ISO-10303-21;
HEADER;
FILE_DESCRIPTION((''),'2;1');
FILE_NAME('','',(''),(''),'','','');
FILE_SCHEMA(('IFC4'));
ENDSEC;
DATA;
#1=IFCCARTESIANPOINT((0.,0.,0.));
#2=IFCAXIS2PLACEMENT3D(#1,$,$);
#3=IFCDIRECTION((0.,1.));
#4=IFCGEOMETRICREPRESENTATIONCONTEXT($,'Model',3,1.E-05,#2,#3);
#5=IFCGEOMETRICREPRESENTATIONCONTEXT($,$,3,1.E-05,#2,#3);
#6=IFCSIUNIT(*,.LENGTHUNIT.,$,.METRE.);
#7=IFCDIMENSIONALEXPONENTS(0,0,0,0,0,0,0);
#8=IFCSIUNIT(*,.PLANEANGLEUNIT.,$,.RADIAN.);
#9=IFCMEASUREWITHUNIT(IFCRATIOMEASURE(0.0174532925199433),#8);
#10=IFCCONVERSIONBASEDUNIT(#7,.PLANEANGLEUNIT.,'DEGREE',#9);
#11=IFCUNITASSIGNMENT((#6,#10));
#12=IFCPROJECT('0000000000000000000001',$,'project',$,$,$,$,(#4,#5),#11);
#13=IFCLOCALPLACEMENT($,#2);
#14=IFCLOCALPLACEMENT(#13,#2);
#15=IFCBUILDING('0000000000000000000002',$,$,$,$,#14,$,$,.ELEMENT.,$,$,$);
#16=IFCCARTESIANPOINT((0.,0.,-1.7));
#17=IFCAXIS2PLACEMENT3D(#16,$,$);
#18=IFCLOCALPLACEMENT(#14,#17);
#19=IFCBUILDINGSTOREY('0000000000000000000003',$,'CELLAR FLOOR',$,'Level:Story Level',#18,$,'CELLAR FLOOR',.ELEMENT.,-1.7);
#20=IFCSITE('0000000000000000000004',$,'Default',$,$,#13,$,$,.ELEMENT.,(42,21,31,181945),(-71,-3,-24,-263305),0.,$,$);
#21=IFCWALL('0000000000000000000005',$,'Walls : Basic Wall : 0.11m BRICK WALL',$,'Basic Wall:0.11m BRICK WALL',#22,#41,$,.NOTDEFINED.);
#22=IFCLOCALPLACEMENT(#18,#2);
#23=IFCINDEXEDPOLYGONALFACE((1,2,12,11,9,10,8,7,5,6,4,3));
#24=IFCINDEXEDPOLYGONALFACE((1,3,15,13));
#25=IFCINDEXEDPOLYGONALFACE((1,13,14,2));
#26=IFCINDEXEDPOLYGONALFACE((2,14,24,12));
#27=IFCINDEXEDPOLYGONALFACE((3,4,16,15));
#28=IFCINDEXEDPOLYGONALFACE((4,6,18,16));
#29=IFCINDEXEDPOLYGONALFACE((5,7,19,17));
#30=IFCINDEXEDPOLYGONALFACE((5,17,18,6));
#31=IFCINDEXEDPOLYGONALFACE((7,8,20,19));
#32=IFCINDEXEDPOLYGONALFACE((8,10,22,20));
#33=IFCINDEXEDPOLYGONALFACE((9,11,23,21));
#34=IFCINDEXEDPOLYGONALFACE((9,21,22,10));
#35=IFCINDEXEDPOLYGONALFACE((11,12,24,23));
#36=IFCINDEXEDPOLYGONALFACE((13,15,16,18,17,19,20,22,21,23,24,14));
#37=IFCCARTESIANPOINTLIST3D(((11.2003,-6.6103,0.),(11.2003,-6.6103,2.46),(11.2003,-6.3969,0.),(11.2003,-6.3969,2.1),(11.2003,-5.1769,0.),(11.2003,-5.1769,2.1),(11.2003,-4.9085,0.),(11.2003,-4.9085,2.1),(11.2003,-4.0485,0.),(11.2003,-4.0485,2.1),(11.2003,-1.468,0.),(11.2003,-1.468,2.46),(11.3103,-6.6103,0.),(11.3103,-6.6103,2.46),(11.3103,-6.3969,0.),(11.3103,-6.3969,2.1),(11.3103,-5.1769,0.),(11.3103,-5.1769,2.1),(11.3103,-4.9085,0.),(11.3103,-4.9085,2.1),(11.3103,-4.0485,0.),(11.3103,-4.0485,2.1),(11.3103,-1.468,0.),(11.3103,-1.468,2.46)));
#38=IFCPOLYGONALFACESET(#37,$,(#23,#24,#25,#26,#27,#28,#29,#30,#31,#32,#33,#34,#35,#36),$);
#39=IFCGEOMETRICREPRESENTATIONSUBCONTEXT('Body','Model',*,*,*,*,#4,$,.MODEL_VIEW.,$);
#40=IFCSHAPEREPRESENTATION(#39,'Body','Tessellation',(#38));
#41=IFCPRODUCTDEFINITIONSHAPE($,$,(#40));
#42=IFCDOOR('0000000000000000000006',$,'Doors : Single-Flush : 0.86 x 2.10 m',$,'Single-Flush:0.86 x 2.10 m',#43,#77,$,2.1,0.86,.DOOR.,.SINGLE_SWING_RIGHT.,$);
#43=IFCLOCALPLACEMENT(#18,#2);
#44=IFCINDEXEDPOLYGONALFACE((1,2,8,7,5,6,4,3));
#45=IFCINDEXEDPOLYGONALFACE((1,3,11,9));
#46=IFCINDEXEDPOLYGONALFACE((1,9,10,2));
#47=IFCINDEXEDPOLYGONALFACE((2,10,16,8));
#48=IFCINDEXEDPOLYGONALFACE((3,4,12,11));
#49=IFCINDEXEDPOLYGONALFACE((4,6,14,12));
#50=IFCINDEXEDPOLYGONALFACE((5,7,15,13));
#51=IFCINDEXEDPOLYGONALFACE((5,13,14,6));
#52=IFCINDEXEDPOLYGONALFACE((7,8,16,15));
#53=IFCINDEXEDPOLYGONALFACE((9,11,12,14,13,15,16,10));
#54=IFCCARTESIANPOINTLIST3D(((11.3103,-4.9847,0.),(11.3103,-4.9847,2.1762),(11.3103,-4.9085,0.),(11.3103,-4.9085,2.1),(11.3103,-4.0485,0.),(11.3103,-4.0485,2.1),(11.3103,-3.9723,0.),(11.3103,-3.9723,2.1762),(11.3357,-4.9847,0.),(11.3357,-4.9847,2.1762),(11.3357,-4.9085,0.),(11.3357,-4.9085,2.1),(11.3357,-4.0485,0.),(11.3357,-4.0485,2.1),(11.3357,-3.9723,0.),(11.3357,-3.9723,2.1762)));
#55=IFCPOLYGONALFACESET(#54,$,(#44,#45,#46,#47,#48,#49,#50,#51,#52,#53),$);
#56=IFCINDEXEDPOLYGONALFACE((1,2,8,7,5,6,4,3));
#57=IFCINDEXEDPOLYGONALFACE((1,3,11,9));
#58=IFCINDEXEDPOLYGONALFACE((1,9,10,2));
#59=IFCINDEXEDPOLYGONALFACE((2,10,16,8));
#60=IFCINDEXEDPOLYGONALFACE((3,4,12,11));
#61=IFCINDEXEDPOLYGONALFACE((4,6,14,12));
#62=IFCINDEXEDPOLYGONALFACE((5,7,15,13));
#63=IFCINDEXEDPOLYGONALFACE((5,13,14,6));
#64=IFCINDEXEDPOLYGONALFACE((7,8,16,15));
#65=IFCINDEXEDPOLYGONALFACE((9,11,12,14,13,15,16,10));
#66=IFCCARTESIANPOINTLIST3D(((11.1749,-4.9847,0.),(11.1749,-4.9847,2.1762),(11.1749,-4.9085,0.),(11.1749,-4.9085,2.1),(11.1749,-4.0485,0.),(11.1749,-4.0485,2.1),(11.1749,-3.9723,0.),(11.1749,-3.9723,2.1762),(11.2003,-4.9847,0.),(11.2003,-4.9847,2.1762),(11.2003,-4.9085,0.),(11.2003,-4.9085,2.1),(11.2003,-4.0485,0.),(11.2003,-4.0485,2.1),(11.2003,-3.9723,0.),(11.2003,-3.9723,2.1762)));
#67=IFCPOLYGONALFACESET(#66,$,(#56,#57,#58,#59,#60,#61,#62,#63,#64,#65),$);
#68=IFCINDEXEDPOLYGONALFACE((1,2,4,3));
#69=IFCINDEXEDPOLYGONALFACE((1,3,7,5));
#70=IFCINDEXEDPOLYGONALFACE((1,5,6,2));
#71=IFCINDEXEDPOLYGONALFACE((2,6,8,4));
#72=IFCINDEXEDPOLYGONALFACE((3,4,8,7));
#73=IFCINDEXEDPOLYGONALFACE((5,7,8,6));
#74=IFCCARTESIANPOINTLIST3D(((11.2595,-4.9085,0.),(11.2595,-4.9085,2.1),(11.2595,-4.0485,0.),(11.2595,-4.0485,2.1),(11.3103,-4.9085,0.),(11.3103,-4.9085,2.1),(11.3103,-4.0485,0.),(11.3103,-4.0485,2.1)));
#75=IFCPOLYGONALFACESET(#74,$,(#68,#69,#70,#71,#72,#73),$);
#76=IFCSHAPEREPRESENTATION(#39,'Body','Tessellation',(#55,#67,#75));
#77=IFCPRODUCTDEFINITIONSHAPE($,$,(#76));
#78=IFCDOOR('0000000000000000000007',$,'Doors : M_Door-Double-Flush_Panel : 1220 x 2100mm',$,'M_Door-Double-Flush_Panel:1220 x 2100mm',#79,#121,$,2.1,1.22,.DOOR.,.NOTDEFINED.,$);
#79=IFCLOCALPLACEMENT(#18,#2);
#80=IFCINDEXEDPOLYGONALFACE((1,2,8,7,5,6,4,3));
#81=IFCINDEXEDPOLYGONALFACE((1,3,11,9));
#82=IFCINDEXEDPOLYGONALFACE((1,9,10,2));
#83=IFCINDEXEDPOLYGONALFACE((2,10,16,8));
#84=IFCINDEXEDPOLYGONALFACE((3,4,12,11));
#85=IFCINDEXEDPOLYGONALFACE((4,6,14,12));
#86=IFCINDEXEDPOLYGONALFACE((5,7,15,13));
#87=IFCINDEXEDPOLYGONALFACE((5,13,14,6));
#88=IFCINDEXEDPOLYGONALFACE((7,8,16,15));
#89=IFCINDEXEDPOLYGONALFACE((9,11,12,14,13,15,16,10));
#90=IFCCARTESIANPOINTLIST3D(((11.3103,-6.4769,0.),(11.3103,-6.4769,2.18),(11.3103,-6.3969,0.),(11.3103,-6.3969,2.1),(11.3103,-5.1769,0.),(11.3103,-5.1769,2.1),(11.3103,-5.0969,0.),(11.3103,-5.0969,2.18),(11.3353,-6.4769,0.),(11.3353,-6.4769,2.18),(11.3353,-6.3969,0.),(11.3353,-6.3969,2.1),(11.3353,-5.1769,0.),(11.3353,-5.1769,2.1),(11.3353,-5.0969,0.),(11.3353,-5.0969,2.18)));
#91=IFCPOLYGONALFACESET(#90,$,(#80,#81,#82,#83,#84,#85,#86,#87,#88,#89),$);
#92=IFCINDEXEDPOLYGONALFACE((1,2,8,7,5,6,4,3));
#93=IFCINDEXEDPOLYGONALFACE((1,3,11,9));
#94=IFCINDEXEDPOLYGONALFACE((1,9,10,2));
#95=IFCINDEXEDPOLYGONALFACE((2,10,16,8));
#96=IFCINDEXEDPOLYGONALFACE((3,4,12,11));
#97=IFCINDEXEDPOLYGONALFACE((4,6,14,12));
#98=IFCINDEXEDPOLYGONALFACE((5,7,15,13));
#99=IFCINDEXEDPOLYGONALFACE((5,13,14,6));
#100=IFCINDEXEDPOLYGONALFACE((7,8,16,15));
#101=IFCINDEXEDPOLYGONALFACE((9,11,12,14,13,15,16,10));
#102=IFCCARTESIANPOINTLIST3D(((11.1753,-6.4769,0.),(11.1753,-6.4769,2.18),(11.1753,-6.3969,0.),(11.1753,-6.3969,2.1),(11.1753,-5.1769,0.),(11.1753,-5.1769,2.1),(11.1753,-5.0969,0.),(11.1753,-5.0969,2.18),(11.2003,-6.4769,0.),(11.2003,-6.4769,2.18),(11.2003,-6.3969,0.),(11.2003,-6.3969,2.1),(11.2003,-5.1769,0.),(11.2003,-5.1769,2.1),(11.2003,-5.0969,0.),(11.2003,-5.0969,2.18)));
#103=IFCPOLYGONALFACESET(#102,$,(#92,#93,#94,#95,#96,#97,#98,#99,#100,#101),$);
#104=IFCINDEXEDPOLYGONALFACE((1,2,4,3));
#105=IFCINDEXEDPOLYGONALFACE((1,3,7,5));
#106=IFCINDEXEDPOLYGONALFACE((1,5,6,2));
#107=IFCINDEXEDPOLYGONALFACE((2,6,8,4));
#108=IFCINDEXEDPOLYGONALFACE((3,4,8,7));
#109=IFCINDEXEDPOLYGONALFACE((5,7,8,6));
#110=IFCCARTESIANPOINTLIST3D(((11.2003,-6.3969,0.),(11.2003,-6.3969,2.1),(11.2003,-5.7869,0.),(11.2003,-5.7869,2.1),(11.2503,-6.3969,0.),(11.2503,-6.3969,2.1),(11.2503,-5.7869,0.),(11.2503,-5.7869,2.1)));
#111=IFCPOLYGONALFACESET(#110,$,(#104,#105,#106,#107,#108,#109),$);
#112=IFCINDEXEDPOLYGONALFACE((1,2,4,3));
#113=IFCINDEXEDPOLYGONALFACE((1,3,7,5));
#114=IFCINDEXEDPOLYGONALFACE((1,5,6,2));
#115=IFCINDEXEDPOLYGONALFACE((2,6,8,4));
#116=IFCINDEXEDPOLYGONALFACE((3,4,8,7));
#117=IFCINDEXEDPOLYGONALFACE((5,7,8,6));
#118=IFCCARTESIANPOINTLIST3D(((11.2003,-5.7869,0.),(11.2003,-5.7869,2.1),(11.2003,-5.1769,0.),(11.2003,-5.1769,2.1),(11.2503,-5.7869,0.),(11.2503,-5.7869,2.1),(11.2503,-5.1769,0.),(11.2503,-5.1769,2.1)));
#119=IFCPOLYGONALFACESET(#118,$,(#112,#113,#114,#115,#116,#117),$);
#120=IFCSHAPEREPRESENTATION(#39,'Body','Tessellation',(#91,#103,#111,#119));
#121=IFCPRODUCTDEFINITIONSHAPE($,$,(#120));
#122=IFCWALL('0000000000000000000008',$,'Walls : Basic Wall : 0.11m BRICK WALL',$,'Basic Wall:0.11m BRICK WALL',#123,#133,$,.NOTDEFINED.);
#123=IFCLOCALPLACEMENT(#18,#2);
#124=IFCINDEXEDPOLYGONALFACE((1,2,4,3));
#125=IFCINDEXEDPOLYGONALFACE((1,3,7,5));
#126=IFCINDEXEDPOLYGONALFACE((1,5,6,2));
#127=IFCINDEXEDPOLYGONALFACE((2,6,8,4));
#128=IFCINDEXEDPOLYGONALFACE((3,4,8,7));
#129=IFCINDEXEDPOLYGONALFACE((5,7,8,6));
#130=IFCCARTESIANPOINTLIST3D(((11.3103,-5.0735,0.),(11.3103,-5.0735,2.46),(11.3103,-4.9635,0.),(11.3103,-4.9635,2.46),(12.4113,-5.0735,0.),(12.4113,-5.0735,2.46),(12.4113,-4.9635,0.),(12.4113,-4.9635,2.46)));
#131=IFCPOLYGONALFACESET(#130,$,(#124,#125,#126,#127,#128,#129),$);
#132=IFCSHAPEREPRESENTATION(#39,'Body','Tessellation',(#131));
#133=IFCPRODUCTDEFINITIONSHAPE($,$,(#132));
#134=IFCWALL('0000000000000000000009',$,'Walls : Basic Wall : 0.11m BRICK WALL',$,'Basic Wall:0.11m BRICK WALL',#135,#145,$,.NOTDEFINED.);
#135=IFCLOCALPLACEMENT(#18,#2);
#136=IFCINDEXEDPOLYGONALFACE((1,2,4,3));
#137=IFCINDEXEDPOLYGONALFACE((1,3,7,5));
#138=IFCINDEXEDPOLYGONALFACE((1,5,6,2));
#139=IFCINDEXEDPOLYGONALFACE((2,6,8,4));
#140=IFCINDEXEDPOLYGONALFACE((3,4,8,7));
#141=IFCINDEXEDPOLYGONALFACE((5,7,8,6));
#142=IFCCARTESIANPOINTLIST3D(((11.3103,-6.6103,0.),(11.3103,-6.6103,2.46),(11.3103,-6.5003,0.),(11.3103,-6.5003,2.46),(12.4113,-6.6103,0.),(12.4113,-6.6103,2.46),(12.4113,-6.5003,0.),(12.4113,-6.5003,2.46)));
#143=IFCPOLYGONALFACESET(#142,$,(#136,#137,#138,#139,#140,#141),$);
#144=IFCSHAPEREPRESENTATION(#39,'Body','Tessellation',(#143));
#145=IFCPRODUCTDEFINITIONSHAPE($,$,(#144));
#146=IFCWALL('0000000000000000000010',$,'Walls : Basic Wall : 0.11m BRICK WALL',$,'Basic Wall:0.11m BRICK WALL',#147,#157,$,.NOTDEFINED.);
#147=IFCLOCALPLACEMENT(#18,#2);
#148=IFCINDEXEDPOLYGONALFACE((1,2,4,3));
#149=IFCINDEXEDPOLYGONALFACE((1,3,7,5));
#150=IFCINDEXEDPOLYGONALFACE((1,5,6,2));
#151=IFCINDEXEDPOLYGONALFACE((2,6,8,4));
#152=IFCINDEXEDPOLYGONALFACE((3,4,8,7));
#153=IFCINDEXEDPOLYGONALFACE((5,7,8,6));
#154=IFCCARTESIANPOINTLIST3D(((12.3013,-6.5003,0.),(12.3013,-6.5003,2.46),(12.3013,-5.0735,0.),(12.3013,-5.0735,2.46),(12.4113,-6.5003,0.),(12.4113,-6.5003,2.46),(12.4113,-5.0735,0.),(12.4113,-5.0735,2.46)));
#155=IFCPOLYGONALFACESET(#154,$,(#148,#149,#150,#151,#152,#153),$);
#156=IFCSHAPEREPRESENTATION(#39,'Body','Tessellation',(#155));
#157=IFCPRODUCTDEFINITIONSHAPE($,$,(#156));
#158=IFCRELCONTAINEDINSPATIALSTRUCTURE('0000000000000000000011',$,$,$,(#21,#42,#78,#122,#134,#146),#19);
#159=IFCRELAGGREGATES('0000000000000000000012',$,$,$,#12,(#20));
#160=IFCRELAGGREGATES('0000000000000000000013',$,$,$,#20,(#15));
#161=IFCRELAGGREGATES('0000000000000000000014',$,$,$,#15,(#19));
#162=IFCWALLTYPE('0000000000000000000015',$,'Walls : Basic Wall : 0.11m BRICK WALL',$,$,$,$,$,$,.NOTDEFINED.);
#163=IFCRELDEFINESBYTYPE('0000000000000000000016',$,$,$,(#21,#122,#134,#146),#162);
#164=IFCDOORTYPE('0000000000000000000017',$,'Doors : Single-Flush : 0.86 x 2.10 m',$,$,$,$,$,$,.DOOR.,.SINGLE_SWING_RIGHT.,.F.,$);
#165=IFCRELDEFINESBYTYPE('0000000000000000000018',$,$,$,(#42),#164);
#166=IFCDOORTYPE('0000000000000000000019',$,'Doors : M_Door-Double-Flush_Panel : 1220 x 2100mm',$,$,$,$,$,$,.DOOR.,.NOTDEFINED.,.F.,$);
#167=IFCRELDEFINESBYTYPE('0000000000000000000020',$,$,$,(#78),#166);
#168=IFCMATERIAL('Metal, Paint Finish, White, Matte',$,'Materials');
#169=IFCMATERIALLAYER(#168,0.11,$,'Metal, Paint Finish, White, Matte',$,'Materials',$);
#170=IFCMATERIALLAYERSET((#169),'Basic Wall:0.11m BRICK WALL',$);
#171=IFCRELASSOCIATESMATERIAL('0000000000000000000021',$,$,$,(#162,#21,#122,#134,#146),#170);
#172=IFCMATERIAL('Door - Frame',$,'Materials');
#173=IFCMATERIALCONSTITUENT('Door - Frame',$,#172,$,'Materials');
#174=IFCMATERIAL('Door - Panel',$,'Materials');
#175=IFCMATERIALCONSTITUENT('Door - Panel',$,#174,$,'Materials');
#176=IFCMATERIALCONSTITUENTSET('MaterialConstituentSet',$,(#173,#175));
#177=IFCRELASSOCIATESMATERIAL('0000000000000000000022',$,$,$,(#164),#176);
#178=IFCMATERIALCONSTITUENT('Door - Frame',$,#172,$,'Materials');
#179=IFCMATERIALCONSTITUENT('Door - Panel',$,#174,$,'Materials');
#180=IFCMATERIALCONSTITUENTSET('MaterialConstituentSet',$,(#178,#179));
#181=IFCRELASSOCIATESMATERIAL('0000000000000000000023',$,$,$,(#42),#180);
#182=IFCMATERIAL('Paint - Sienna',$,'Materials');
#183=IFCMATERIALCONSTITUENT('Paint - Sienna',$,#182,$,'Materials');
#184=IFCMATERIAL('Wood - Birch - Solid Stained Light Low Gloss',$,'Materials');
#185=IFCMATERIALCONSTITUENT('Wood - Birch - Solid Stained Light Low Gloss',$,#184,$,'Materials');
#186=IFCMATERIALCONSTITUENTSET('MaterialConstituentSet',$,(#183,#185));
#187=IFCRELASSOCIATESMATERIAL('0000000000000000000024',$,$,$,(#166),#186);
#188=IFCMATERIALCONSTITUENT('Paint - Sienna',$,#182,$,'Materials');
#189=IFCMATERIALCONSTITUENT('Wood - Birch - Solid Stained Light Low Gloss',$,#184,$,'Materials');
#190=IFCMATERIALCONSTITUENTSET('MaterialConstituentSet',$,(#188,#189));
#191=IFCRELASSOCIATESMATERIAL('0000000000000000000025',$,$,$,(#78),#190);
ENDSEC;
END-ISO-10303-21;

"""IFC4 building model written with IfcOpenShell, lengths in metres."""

from ifc_helpers import new_model, entity, si_unit, converted_unit, direction, frame, frame_2d, origin, origin_2d_with_axis, place, context, subcontext, project, spatial, polyline, rectangle, outline, extrude, source, transform, mapped, material, layer, layer_set, layer_usage, constituent, constituent_set, type_object, type_shapes, element, fill, save


model = new_model("IFC4")

# Units and contexts
model_context = context("Model", 3, precision=1e-05, world=origin(), true_north=direction((0.0, 1.0)))
context_of_model = context(None, 3, precision=1e-05, world=origin(), true_north=direction((0.0, 1.0)))
body_context = subcontext(model_context, "Body", "Model", "MODEL_VIEW")
ifc_project = project(units=[si_unit("LENGTHUNIT", "METRE"), converted_unit("PLANEANGLEUNIT", "DEGREE", entity("IfcRatioMeasure", 0.0174532925199433), si_unit("PLANEANGLEUNIT", "RADIAN"), dimensions=[0, 0, 0, 0, 0, 0, 0])], contexts=[model_context, context_of_model])

# Site, building, storey
site_placement = place(None, origin())
site = spatial("IfcSite", under=ifc_project, at=site_placement, Name="Default", CompositionType="ELEMENT", RefLatitude=(42, 21, 31, 181945), RefLongitude=(-71, -3, -24, -263305), RefElevation=0.0)
building_placement = place(site_placement, origin())
building = spatial("IfcBuilding", under=site, at=building_placement, CompositionType="ELEMENT")
storey_placement = place(building_placement, frame((0.0, 0.0, -1.7)))
storey = spatial("IfcBuildingStorey", under=building, at=storey_placement, Name="CELLAR FLOOR", ObjectType="Level:Story Level", LongName="CELLAR FLOOR", CompositionType="ELEMENT", Elevation=-1.7)

# Shared definitions
ifc_material_1 = material(Name="Metal, Paint Finish, White, Matte", Category="Materials")
ifc_material_2 = material(Name="Door - Frame", Category="Materials")
ifc_material_3 = material(Name="Door - Panel", Category="Materials")

# Wall, openings, doors
ifc_layer_1 = layer(ifc_material_1, 0.11, Name="Metal, Paint Finish, White, Matte", Category="Materials")
ifc_layer_set_1 = layer_set([ifc_layer_1], Name="Basic Wall:0.11m BRICK WALL")
ifc_layer_usage_1 = layer_usage(ifc_layer_set_1, "AXIS2", "NEGATIVE", 0.055)
wall_type_1 = type_object("IfcWallType", Name="Walls : Basic Wall : 0.11m BRICK WALL", PredefinedType="NOTDEFINED", material=ifc_layer_set_1)
wall_1_placement = place(storey_placement, frame((11.2553, -6.6103, 0.0), z_axis=(0.0, 0.0, 1.0), x_axis=(0.0, 1.0, 0.0)))
wall_1 = element("IfcWall", 1, at=wall_1_placement, inside=storey, type_object=wall_type_1, material=ifc_layer_usage_1, Name="Walls : Basic Wall : 0.11m BRICK WALL", ObjectType="Basic Wall:0.11m BRICK WALL", PredefinedType="NOTDEFINED", context=body_context, shape_type="SweptSolid", body=[
    extrude(rectangle(XDim=5.1423, YDim=0.11, at=frame_2d((2.5712, 0.0), x_axis=(-1.0, 0.0))), origin(), (0.0, 0.0, 1.0), 2.46),
])
opening_1_placement = place(wall_1_placement, frame((2.5618, 0.055, 0.0)))
opening_1 = element("IfcOpeningElement", 2, at=opening_1_placement, cuts=wall_1, ObjectType="Opening", PredefinedType="OPENING", context=body_context, shape_type="SweptSolid", body=[
    extrude(rectangle(XDim=0.86, YDim=2.1, at=frame_2d((1.05, 0.43), x_axis=(0.0, 1.0))), frame((0.0, 0.0, 0.0), z_axis=(0.0, -1.0, 0.0), x_axis=(0.0, 0.0, 1.0)), (0.0, 0.0, 1.0), 0.11),
])
opening_2_placement = place(wall_1_placement, frame((0.2134, -0.055, 0.0)))
opening_2 = element("IfcOpeningElement", 3, at=opening_2_placement, cuts=wall_1, ObjectType="Opening", PredefinedType="OPENING", context=body_context, shape_type="SweptSolid", body=[
    extrude(rectangle(XDim=2.1, YDim=1.22, at=frame_2d((1.05, 0.61), x_axis=(1.0, 0.0))), frame((0.0, 0.0, 0.0), z_axis=(0.0, 1.0, 0.0), x_axis=(0.0, 0.0, 1.0)), (0.0, 0.0, 1.0), 0.11),
])
ifc_constituent_1 = constituent(ifc_material_2, Name="Door - Frame", Category="Materials")
ifc_constituent_2 = constituent(ifc_material_3, Name="Door - Panel", Category="Materials")
ifc_constituent_set_1 = constituent_set(constituents=[ifc_constituent_1, ifc_constituent_2], Name="MaterialConstituentSet")
ifc_constituent_3 = constituent(ifc_material_2, Name="Door - Frame", Category="Materials")
ifc_constituent_4 = constituent(ifc_material_3, Name="Door - Panel", Category="Materials")
ifc_constituent_set_2 = constituent_set(constituents=[ifc_constituent_3, ifc_constituent_4], Name="MaterialConstituentSet")
door_type_1 = type_object("IfcDoorType", Name="Doors : Single-Flush : 0.86 x 2.10 m", OperationType="SINGLE_SWING_RIGHT", ParameterTakesPrecedence=False, PredefinedType="DOOR", material=ifc_constituent_set_2)
shared_shape_1 = source(origin(), body_context, "Body", "SweptSolid", [
    extrude(outline(polyline([(-0.5062, -1.1072), (0.5062, -1.1072), (0.5062, 1.0691), (0.43, 1.0691), (0.43, -1.031), (-0.43, -1.031), (-0.43, 1.0691), (-0.5062, 1.0691), (-0.5062, -1.1072)])), frame((0.43, 0.11, 1.0691), z_axis=(0.0, 1.0, 0.0), x_axis=(1.0, 0.0, 0.0)), (0.0, 0.0, 1.0), 0.0254),
    extrude(outline(polyline([(-1.1072, -0.5062), (1.0691, -0.5062), (1.0691, -0.43), (-1.031, -0.43), (-1.031, 0.43), (1.0691, 0.43), (1.0691, 0.5062), (-1.1072, 0.5062), (-1.1072, -0.5062)])), frame((0.43, -0.0254, 1.0691), z_axis=(0.0, 1.0, 0.0), x_axis=(0.0, 0.0, -1.0)), (0.0, 0.0, 1.0), 0.0254),
    extrude(rectangle(XDim=0.0508, YDim=0.86, at=origin_2d_with_axis()), frame((0.43, 0.0846, 0.0), z_axis=(0.0, 0.0, 1.0), x_axis=(0.0, 1.0, 0.0)), (0.0, 0.0, 1.0), 2.1),
])
type_shapes(door_type_1, [shared_shape_1])
door_1_placement = place(opening_1_placement, frame((0.0, 0.0, 0.0), z_axis=(0.0, 0.0, 1.0), x_axis=(-1.0, 0.0, 0.0)))
door_1 = element("IfcDoor", 4, at=door_1_placement, inside=storey, type_object=door_type_1, material=ifc_constituent_set_1, Name="Doors : Single-Flush : 0.86 x 2.10 m", ObjectType="Single-Flush:0.86 x 2.10 m", OperationType="SINGLE_SWING_RIGHT", OverallHeight=2.1, OverallWidth=0.86, PredefinedType="DOOR", context=body_context, shape_type="MappedRepresentation", body=[
    mapped(shared_shape_1, transform((0.0, 0.0, 0.0), scale=1.0)),
])
fill(opening_1, door_1)
ifc_material_4 = material(Name="Paint - Sienna", Category="Materials")
ifc_constituent_5 = constituent(ifc_material_4, Name="Paint - Sienna", Category="Materials")
ifc_material_5 = material(Name="Wood - Birch - Solid Stained Light Low Gloss", Category="Materials")
ifc_constituent_6 = constituent(ifc_material_5, Name="Wood - Birch - Solid Stained Light Low Gloss", Category="Materials")
ifc_constituent_set_3 = constituent_set(constituents=[ifc_constituent_5, ifc_constituent_6], Name="MaterialConstituentSet")
ifc_constituent_7 = constituent(ifc_material_4, Name="Paint - Sienna", Category="Materials")
ifc_constituent_8 = constituent(ifc_material_5, Name="Wood - Birch - Solid Stained Light Low Gloss", Category="Materials")
ifc_constituent_set_4 = constituent_set(constituents=[ifc_constituent_7, ifc_constituent_8], Name="MaterialConstituentSet")
door_type_2 = type_object("IfcDoorType", Name="Doors : M_Door-Double-Flush_Panel : 1220 x 2100mm", OperationType="NOTDEFINED", ParameterTakesPrecedence=False, PredefinedType="DOOR", material=ifc_constituent_set_4)
shared_shape_2 = source(origin(), body_context, "Body", "SweptSolid", [
    extrude(outline(polyline([(-1.03, 0.61), (1.07, 0.61), (1.07, 0.69), (-1.11, 0.69), (-1.11, -0.69), (1.07, -0.69), (1.07, -0.61), (-1.03, -0.61), (-1.03, 0.61)])), frame((0.61, 0.0, 1.07), z_axis=(0.0, -1.0, 0.0), x_axis=(0.0, 0.0, -1.0)), (0.0, 0.0, 1.0), 0.025),
    extrude(outline(polyline([(-1.03, 0.61), (1.07, 0.61), (1.07, 0.69), (-1.11, 0.69), (-1.11, -0.69), (1.07, -0.69), (1.07, -0.61), (-1.03, -0.61), (-1.03, 0.61)])), frame((0.61, 0.135, 1.07), z_axis=(0.0, -1.0, 0.0), x_axis=(0.0, 0.0, -1.0)), (0.0, 0.0, 1.0), 0.025),
    extrude(rectangle(XDim=0.61, YDim=0.05, at=origin_2d_with_axis()), frame((0.305, 0.085, 0.0), z_axis=(0.0, 0.0, 1.0), x_axis=(-1.0, 0.0, 0.0)), (0.0, 0.0, 1.0), 2.1),
    extrude(rectangle(XDim=0.61, YDim=0.05, at=frame_2d((0.0, 0.0), x_axis=(1.0, 0.0))), frame((0.915, 0.085, 0.0), z_axis=(0.0, 0.0, 1.0), x_axis=(-1.0, 0.0, 0.0)), (0.0, 0.0, 1.0), 2.1),
])
type_shapes(door_type_2, [shared_shape_2])
door_2_placement = place(opening_2_placement, origin())
door_2 = element("IfcDoor", 5, at=door_2_placement, inside=storey, type_object=door_type_2, material=ifc_constituent_set_3, Name="Doors : M_Door-Double-Flush_Panel : 1220 x 2100mm", ObjectType="M_Door-Double-Flush_Panel:1220 x 2100mm", OperationType="NOTDEFINED", OverallHeight=2.1, OverallWidth=1.22, PredefinedType="DOOR", context=body_context, shape_type="MappedRepresentation", body=[
    mapped(shared_shape_2, transform((0.0, 0.0, 0.0), scale=1.0)),
])
fill(opening_2, door_2)

# Walls
ifc_layer_usage_2 = layer_usage(ifc_layer_set_1, "AXIS2", "NEGATIVE", 0.055)
wall_2_placement = place(storey_placement, frame((11.3103, -5.0185, 0.0)))
element("IfcWall", 6, at=wall_2_placement, inside=storey, type_object=wall_type_1, material=ifc_layer_usage_2, Name="Walls : Basic Wall : 0.11m BRICK WALL", ObjectType="Basic Wall:0.11m BRICK WALL", PredefinedType="NOTDEFINED", context=body_context, shape_type="SweptSolid", body=[
    extrude(rectangle(XDim=1.1009, YDim=0.11, at=frame_2d((0.5505, 0.0), x_axis=(-1.0, 0.0))), origin(), (0.0, 0.0, 1.0), 2.46),
])
ifc_layer_usage_3 = layer_usage(ifc_layer_set_1, "AXIS2", "NEGATIVE", 0.055)
wall_3_placement = place(storey_placement, frame((12.4113, -6.5553, 0.0), z_axis=(0.0, 0.0, 1.0), x_axis=(-1.0, 0.0, 0.0)))
element("IfcWall", 7, at=wall_3_placement, inside=storey, type_object=wall_type_1, material=ifc_layer_usage_3, Name="Walls : Basic Wall : 0.11m BRICK WALL", ObjectType="Basic Wall:0.11m BRICK WALL", PredefinedType="NOTDEFINED", context=body_context, shape_type="SweptSolid", body=[
    extrude(rectangle(XDim=1.1009, YDim=0.11, at=frame_2d((0.5505, 0.0), x_axis=(-1.0, 0.0))), origin(), (0.0, 0.0, 1.0), 2.46),
])
ifc_layer_usage_4 = layer_usage(ifc_layer_set_1, "AXIS2", "NEGATIVE", 0.055)
wall_4_placement = place(storey_placement, frame((12.3563, -6.5003, 0.0), z_axis=(0.0, 0.0, 1.0), x_axis=(0.0, 1.0, 0.0)))
element("IfcWall", 8, at=wall_4_placement, inside=storey, type_object=wall_type_1, material=ifc_layer_usage_4, Name="Walls : Basic Wall : 0.11m BRICK WALL", ObjectType="Basic Wall:0.11m BRICK WALL", PredefinedType="NOTDEFINED", context=body_context, shape_type="SweptSolid", body=[
    extrude(rectangle(XDim=1.4268, YDim=0.11, at=frame_2d((0.7134, 0.0), x_axis=(-1.0, 0.0))), origin(), (0.0, 0.0, 1.0), 2.46),
])

save(model, "model.ifc")
